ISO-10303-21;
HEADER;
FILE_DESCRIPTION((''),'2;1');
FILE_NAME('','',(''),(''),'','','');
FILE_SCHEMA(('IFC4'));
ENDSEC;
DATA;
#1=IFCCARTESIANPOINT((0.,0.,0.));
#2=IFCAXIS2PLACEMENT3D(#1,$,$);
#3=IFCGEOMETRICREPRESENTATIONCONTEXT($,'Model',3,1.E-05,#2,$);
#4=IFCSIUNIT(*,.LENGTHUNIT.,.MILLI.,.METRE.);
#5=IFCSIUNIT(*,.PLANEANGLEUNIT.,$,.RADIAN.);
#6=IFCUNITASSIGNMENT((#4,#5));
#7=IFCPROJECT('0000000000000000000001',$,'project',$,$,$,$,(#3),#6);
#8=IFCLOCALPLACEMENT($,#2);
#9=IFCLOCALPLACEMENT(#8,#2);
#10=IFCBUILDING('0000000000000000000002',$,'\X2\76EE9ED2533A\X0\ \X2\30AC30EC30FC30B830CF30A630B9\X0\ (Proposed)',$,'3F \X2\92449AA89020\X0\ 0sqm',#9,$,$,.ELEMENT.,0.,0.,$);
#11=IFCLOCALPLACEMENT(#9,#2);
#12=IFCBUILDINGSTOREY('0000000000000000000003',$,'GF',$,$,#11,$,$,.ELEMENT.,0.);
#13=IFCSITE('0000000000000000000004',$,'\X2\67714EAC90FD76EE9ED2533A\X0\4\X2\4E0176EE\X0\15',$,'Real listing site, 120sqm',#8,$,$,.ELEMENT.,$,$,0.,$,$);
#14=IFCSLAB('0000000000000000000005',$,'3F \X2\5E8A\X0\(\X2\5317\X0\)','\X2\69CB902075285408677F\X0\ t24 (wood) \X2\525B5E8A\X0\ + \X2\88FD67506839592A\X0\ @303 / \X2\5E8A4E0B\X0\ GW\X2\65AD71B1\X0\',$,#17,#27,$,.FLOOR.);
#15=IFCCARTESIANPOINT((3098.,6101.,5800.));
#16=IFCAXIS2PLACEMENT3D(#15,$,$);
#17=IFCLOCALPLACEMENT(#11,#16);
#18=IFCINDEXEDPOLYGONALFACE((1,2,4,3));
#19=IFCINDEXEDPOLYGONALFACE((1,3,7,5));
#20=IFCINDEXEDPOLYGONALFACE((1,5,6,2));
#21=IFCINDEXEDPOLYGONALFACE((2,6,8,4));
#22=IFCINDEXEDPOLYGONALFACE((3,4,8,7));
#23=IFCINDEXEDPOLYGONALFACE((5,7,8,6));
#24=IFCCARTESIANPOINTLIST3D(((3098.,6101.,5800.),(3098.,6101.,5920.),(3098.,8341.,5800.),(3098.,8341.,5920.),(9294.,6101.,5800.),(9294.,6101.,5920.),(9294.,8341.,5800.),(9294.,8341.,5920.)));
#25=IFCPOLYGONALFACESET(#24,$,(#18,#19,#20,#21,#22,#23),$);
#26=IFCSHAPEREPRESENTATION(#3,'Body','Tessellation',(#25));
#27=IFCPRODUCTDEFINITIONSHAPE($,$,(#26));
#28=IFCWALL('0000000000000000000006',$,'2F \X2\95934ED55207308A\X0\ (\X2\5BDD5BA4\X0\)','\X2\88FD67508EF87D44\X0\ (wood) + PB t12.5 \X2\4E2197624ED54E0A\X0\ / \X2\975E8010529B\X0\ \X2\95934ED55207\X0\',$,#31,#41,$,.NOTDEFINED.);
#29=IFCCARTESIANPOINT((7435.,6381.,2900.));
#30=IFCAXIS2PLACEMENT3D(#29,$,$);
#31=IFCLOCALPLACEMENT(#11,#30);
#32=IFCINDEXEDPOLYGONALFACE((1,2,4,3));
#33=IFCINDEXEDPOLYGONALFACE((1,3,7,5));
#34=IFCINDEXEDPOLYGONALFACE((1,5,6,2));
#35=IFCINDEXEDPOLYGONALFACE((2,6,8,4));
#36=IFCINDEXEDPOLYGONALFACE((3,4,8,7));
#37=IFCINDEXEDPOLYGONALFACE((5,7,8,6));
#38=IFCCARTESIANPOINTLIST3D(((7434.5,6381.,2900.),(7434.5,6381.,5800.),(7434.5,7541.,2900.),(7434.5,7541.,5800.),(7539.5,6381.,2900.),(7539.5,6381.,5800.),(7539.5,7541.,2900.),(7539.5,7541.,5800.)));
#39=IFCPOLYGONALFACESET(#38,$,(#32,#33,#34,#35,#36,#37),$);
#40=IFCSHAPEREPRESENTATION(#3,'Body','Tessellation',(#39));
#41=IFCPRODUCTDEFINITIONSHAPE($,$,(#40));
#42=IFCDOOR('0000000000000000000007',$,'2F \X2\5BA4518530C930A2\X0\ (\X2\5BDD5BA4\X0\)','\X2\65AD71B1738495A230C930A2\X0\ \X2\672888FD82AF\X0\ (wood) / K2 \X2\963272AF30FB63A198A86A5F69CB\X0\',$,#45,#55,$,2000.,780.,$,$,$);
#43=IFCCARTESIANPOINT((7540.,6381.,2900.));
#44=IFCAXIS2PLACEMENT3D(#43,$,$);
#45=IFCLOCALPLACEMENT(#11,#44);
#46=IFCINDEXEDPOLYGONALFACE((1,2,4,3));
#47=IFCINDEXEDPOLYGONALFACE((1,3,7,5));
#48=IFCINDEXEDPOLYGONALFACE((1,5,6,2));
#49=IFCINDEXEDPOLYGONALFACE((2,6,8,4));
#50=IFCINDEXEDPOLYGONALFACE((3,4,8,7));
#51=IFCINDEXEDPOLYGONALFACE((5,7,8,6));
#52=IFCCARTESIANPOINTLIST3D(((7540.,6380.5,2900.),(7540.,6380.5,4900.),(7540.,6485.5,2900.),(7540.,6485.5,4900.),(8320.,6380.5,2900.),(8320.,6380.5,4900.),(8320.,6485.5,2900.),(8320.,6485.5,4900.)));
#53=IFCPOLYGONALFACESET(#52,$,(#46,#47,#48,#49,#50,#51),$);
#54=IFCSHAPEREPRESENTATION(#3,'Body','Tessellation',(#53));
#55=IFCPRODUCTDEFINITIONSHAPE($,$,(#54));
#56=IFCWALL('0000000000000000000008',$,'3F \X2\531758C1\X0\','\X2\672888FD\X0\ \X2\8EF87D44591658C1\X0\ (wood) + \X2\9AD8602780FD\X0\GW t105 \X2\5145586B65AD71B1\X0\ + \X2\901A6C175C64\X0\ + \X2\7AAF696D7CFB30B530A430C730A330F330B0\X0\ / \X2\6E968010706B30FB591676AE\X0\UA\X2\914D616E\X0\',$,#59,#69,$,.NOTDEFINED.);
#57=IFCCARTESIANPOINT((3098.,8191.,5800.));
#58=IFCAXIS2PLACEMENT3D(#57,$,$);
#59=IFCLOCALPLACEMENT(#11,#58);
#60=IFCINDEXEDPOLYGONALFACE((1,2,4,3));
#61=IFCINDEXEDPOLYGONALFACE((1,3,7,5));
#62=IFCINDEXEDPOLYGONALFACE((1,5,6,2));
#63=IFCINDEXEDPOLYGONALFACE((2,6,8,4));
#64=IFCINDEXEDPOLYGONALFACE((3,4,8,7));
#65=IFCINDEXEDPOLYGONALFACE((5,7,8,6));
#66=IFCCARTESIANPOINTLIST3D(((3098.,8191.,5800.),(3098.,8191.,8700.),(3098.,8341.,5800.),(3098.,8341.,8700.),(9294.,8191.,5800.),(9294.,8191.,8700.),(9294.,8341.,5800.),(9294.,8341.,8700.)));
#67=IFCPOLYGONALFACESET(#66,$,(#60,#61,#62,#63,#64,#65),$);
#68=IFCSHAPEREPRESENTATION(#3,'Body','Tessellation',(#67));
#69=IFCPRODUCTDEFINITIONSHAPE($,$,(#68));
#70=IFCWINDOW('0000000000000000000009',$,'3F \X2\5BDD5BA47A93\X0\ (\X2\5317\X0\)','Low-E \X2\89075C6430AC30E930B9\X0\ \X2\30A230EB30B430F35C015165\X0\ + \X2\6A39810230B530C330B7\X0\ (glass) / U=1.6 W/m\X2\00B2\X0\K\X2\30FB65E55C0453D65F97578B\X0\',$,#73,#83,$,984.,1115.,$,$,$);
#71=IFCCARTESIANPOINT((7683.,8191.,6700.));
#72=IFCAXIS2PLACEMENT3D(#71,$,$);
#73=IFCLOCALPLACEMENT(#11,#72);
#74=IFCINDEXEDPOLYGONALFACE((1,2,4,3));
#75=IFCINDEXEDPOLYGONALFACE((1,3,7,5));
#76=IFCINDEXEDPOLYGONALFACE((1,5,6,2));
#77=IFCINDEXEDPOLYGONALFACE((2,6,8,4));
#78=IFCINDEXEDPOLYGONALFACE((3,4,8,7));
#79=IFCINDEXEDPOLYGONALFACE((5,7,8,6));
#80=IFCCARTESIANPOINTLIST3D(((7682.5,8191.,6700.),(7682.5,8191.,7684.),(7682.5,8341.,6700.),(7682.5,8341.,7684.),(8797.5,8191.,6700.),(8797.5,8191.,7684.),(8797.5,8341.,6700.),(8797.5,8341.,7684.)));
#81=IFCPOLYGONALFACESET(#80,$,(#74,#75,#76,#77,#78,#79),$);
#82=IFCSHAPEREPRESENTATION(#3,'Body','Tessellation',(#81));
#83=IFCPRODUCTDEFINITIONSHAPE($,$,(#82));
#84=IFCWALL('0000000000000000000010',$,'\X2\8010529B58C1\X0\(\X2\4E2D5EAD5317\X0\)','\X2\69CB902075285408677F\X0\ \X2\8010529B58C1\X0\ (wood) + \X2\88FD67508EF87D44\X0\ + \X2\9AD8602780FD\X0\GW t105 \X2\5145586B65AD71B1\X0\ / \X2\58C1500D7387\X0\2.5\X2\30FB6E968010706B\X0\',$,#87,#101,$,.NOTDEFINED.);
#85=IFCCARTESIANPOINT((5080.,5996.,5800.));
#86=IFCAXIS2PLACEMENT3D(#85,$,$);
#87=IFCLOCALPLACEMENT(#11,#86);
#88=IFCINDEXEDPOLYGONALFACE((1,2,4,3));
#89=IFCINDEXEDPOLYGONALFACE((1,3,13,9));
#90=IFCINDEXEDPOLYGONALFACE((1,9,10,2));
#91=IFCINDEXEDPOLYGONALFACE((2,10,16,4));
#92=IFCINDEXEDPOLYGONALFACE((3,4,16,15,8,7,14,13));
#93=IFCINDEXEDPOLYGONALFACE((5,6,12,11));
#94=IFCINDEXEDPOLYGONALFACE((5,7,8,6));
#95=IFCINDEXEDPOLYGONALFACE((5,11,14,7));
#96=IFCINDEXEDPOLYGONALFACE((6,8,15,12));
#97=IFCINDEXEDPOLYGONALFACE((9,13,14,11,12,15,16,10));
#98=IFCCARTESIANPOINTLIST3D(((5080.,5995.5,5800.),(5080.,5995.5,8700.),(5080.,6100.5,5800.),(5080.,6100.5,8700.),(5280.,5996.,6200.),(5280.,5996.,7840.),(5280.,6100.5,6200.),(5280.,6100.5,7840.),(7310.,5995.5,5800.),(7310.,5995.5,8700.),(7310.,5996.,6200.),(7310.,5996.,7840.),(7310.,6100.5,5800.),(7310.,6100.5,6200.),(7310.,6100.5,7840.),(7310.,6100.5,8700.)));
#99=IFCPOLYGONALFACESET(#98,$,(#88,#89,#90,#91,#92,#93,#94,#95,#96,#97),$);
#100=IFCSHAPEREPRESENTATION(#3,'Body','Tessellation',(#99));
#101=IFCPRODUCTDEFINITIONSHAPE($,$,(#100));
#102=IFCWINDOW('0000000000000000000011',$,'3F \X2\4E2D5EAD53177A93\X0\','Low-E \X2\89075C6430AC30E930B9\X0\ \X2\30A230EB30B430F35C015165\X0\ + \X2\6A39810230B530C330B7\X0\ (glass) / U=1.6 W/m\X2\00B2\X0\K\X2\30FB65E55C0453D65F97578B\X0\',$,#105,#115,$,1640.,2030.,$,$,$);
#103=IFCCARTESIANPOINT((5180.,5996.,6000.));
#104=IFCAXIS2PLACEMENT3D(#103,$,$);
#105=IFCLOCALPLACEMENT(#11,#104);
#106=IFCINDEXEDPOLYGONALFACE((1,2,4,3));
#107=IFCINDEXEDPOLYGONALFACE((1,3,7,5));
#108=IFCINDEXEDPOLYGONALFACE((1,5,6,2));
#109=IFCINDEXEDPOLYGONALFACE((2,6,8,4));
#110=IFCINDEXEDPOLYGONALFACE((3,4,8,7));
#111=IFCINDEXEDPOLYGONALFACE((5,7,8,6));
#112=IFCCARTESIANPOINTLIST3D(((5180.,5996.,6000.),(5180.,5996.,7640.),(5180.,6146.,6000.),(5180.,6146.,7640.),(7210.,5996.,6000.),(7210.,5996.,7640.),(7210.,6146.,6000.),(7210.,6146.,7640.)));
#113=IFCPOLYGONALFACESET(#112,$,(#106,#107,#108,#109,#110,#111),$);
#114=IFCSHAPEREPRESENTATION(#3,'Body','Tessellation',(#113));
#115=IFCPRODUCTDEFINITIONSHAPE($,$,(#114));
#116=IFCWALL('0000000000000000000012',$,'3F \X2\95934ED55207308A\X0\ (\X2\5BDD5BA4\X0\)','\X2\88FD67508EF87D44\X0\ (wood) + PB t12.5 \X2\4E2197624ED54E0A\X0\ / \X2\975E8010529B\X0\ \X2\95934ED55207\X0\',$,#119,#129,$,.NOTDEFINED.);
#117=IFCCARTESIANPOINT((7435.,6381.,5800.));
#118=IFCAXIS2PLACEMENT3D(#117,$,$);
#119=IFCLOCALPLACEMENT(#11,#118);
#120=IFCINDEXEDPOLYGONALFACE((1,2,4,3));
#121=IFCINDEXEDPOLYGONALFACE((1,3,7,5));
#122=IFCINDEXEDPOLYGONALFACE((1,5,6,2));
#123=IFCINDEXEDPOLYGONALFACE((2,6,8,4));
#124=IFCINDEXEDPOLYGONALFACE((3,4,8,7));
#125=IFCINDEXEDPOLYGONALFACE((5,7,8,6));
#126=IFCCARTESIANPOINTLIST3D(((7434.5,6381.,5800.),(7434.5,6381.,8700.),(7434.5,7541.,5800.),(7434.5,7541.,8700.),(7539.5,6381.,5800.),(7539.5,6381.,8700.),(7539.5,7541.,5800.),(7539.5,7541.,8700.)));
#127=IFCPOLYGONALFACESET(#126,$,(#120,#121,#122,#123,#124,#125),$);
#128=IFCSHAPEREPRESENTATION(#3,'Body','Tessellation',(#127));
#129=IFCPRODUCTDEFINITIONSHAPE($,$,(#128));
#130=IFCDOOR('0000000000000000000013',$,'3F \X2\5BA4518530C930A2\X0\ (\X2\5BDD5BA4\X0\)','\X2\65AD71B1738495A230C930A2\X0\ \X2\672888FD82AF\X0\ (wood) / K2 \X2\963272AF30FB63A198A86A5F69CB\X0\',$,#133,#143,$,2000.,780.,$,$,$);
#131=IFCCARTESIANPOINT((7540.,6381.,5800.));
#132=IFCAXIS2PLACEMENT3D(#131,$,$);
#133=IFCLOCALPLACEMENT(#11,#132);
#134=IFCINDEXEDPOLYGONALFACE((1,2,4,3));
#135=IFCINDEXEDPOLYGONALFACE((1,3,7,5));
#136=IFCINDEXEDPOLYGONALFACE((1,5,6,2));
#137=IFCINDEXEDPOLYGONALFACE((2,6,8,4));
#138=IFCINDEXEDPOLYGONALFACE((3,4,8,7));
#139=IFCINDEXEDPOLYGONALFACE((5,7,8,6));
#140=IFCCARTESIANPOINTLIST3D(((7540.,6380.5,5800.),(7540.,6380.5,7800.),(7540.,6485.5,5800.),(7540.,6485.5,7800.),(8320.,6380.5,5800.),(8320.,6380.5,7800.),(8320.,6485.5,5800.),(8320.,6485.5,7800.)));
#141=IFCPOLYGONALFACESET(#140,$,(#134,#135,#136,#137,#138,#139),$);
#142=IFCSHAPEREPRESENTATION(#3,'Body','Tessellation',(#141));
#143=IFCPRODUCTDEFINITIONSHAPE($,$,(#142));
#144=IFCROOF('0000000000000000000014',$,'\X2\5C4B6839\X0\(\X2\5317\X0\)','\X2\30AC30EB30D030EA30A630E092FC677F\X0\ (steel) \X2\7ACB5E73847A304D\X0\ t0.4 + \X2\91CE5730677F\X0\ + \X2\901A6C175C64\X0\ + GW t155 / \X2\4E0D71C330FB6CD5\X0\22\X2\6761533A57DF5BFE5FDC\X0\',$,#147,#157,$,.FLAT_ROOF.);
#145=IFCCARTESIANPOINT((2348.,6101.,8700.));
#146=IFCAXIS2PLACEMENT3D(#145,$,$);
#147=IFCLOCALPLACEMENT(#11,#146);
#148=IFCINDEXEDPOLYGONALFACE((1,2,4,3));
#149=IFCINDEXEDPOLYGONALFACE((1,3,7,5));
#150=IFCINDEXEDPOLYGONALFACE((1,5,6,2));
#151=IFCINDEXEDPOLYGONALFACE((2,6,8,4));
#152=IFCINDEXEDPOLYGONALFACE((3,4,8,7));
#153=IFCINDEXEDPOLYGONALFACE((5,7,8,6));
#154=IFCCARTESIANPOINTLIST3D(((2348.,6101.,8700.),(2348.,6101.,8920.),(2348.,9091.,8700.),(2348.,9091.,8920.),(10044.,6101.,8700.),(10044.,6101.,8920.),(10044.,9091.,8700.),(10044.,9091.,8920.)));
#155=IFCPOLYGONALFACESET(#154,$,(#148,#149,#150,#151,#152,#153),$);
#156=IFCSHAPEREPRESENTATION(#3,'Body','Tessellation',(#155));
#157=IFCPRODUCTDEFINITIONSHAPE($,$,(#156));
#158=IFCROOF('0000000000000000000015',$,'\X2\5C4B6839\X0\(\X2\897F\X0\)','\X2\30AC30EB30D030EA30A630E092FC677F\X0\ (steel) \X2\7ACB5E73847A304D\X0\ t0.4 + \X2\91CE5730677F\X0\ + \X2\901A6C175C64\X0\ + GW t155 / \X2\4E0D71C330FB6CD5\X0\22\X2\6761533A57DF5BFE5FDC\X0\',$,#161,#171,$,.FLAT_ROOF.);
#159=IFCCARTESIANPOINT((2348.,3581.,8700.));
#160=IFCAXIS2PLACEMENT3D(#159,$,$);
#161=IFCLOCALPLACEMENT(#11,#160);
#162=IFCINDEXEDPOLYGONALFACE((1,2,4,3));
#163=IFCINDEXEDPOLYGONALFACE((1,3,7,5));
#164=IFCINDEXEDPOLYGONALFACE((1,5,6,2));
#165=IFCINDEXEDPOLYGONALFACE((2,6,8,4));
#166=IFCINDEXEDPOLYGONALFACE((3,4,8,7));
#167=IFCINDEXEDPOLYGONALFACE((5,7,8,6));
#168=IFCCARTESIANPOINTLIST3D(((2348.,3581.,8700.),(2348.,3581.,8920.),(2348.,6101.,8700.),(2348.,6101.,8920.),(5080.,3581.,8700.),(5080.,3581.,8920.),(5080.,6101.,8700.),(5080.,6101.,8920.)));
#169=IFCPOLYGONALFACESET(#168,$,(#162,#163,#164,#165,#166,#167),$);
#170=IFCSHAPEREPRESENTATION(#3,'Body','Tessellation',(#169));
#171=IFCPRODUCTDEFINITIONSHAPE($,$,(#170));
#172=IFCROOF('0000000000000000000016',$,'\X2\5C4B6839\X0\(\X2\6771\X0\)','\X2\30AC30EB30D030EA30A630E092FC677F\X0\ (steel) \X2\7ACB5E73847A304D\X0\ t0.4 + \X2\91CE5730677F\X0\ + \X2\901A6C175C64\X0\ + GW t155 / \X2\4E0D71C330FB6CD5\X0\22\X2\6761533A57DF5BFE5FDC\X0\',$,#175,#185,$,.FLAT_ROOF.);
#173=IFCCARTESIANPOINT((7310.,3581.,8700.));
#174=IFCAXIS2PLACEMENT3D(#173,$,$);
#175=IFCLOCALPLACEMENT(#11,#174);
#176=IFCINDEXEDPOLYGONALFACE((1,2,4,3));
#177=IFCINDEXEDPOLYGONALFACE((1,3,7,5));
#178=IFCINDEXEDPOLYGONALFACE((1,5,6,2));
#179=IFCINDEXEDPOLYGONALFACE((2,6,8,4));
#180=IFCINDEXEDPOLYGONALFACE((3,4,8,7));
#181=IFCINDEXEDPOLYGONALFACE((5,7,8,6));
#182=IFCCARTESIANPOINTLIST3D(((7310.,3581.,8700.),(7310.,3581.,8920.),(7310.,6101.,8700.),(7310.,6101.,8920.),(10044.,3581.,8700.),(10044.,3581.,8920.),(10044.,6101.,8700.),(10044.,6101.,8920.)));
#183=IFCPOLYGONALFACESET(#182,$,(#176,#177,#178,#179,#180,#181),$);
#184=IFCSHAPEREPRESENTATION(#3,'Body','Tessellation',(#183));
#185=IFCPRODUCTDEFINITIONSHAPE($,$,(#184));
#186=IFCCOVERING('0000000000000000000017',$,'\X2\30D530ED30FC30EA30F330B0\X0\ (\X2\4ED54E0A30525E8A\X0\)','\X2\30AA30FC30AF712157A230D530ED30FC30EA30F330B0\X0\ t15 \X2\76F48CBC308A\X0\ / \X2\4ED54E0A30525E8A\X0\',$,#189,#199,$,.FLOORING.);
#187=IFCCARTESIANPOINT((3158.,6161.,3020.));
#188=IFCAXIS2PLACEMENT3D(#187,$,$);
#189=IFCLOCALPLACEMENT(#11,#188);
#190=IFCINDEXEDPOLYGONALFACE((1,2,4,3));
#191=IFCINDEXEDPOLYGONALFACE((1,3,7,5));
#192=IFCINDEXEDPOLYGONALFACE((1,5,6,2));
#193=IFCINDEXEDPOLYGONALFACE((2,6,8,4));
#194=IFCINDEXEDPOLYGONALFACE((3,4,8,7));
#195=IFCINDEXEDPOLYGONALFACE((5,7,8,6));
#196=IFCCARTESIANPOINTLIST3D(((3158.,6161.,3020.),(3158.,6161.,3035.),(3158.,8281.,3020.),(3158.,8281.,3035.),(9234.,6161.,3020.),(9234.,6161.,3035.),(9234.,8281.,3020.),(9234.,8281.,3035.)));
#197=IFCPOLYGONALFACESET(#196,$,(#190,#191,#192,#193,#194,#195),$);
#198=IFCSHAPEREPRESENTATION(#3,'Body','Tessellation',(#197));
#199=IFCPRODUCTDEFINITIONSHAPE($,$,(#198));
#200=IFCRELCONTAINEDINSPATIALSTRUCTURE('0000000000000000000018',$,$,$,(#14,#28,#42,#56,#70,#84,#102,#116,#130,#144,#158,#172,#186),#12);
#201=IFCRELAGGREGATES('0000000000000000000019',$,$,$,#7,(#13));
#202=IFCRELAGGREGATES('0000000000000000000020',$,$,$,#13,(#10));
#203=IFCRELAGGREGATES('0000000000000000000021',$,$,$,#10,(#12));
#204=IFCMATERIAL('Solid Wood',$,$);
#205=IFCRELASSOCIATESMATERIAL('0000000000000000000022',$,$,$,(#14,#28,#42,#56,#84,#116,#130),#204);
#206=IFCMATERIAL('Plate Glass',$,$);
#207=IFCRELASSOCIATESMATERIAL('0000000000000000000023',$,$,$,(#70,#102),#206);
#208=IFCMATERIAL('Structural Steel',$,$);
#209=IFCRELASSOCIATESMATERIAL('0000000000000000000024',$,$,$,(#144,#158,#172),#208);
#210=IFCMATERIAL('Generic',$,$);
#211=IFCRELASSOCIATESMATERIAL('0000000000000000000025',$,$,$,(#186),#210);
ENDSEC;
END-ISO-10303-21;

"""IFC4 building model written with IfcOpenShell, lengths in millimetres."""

from ifc_helpers import new_model, si_unit, frame, frame_2d, origin, place, context, project, spatial, rectangle, extrude, material, element, fill, save


model = new_model("IFC4")

# Units and contexts
model_context = context("Model", 3, precision=1e-05, world=origin())
ifc_project = project(units=[si_unit("LENGTHUNIT", "METRE", prefix="MILLI"), si_unit("PLANEANGLEUNIT", "RADIAN")], contexts=[model_context])

# Site, building, storey
site_placement = place(None, origin())
site = spatial("IfcSite", under=ifc_project, at=site_placement, Name="東京都目黒区4丁目15", ObjectType="Real listing site, 120sqm", CompositionType="ELEMENT", RefElevation=0.0)
building_placement = place(site_placement, origin())
building = spatial("IfcBuilding", under=site, at=building_placement, Name="目黒区 ガレージハウス (Proposed)", ObjectType="3F 鉄骨造 0sqm", CompositionType="ELEMENT", ElevationOfRefHeight=0.0, ElevationOfTerrain=0.0)
storey_placement = place(building_placement, origin())
storey = spatial("IfcBuildingStorey", under=building, at=storey_placement, Name="GF", CompositionType="ELEMENT", Elevation=0.0)

# Slab
ifc_material_1 = material(Name="Solid Wood")
slab_placement = place(storey_placement, frame((3098.0, 6101.0, 5800.0)))
element("IfcSlab", 1, at=slab_placement, inside=storey, material=ifc_material_1, Name="3F 床(北)", Description="構造用合板 t24 (wood) 剛床 + 製材根太 @303 / 床下 GW断熱", PredefinedType="FLOOR", context=model_context, shape_type="SweptSolid", body=[
    extrude(rectangle(XDim=6196.0, YDim=2240.0, at=frame_2d((3098.0, 1120.0))), frame((3098.0, 6101.0, 5800.0)), (0.0, 0.0, 1.0), 120.0),
])

# Wall
wall_1_placement = place(storey_placement, frame((7435.0, 6381.0, 2900.0)))
element("IfcWall", 2, at=wall_1_placement, inside=storey, material=ifc_material_1, Name="2F 間仕切り (寝室)", Description="製材軸組 (wood) + PB t12.5 両面仕上 / 非耐力 間仕切", PredefinedType="NOTDEFINED", context=model_context, shape_type="SweptSolid", body=[
    extrude(rectangle(XDim=105.0, YDim=1160.0, at=frame_2d((52.0, 580.0))), frame((7435.0, 6381.0, 2900.0)), (0.0, 0.0, 1.0), 2900.0),
])

# Door
door_1_placement = place(storey_placement, frame((7540.0, 6381.0, 2900.0)))
element("IfcDoor", 3, at=door_1_placement, inside=storey, material=ifc_material_1, Name="2F 室内ドア (寝室)", Description="断熱玄関ドア 木製芯 (wood) / K2 防犯・採風機構", OverallHeight=2000.0, OverallWidth=780.0, context=model_context, shape_type="SweptSolid", body=[
    extrude(rectangle(XDim=780.0, YDim=105.0, at=frame_2d((390.0, 52.0))), frame((7540.0, 6381.0, 2900.0)), (0.0, 0.0, 1.0), 2000.0),
])

# Walls, openings, windows
wall_2_placement = place(storey_placement, frame((3098.0, 8191.0, 5800.0)))
wall_2 = element("IfcWall", 4, at=wall_2_placement, inside=storey, material=ifc_material_1, Name="3F 北壁", Description="木製 軸組外壁 (wood) + 高性能GW t105 充填断熱 + 通気層 + 窯業系サイディング / 準耐火・外皮UA配慮", PredefinedType="NOTDEFINED", context=model_context, shape_type="SweptSolid", body=[
    extrude(rectangle(XDim=6196.0, YDim=150.0, at=frame_2d((3098.0, 75.0))), frame((3098.0, 8191.0, 5800.0)), (0.0, 0.0, 1.0), 2900.0),
])
opening_1_placement = place(storey_placement, frame((7683.0, 8191.0, 6700.0)))
opening_1 = element("IfcOpeningElement", 5, at=opening_1_placement, cuts=wall_2, PredefinedType="NOTDEFINED", context=model_context, shape_type="SweptSolid", body=[
    extrude(rectangle(XDim=1115.0, YDim=150.0, at=frame_2d((557.0, 75.0))), frame((7683.0, 8191.0, 6700.0)), (0.0, 0.0, 1.0), 984.0),
])
ifc_material_2 = material(Name="Plate Glass")
window_1_placement = place(storey_placement, frame((7683.0, 8191.0, 6700.0)))
window_1 = element("IfcWindow", 6, at=window_1_placement, inside=storey, material=ifc_material_2, Name="3F 寝室窓 (北)", Description="Low-E 複層ガラス アルゴン封入 + 樹脂サッシ (glass) / U=1.6 W/m²K・日射取得型", OverallHeight=984.0, OverallWidth=1115.0, context=model_context, shape_type="SweptSolid", body=[
    extrude(rectangle(XDim=1115.0, YDim=150.0, at=frame_2d((557.0, 75.0))), frame((7683.0, 8191.0, 6700.0)), (0.0, 0.0, 1.0), 984.0),
])
fill(opening_1, window_1)
wall_3_placement = place(storey_placement, frame((5080.0, 5996.0, 5800.0)))
wall_3 = element("IfcWall", 7, at=wall_3_placement, inside=storey, material=ifc_material_1, Name="耐力壁(中庭北)", Description="構造用合板 耐力壁 (wood) + 製材軸組 + 高性能GW t105 充填断熱 / 壁倍率2.5・準耐火", PredefinedType="NOTDEFINED", context=model_context, shape_type="SweptSolid", body=[
    extrude(rectangle(XDim=2230.0, YDim=105.0, at=frame_2d((1115.0, 52.0))), frame((5080.0, 5996.0, 5800.0)), (0.0, 0.0, 1.0), 2900.0),
])
opening_2_placement = place(storey_placement, frame((5180.0, 5996.0, 6000.0)))
opening_2 = element("IfcOpeningElement", 8, at=opening_2_placement, cuts=wall_3, PredefinedType="NOTDEFINED", context=model_context, shape_type="SweptSolid", body=[
    extrude(rectangle(XDim=2030.0, YDim=150.0, at=frame_2d((1015.0, 75.0))), frame((5180.0, 5996.0, 6000.0)), (0.0, 0.0, 1.0), 1640.0),
])
window_2_placement = place(storey_placement, frame((5180.0, 5996.0, 6000.0)))
window_2 = element("IfcWindow", 9, at=window_2_placement, inside=storey, material=ifc_material_2, Name="3F 中庭北窓", Description="Low-E 複層ガラス アルゴン封入 + 樹脂サッシ (glass) / U=1.6 W/m²K・日射取得型", OverallHeight=1640.0, OverallWidth=2030.0, context=model_context, shape_type="SweptSolid", body=[
    extrude(rectangle(XDim=2030.0, YDim=150.0, at=frame_2d((1015.0, 75.0))), frame((5180.0, 5996.0, 6000.0)), (0.0, 0.0, 1.0), 1640.0),
])
fill(opening_2, window_2)

# Wall
wall_4_placement = place(storey_placement, frame((7435.0, 6381.0, 5800.0)))
element("IfcWall", 10, at=wall_4_placement, inside=storey, material=ifc_material_1, Name="3F 間仕切り (寝室)", Description="製材軸組 (wood) + PB t12.5 両面仕上 / 非耐力 間仕切", PredefinedType="NOTDEFINED", context=model_context, shape_type="SweptSolid", body=[
    extrude(rectangle(XDim=105.0, YDim=1160.0, at=frame_2d((52.0, 580.0))), frame((7435.0, 6381.0, 5800.0)), (0.0, 0.0, 1.0), 2900.0),
])

# Door
door_2_placement = place(storey_placement, frame((7540.0, 6381.0, 5800.0)))
element("IfcDoor", 11, at=door_2_placement, inside=storey, material=ifc_material_1, Name="3F 室内ドア (寝室)", Description="断熱玄関ドア 木製芯 (wood) / K2 防犯・採風機構", OverallHeight=2000.0, OverallWidth=780.0, context=model_context, shape_type="SweptSolid", body=[
    extrude(rectangle(XDim=780.0, YDim=105.0, at=frame_2d((390.0, 52.0))), frame((7540.0, 6381.0, 5800.0)), (0.0, 0.0, 1.0), 2000.0),
])

# Roofs
ifc_material_3 = material(Name="Structural Steel")
for number, where, name in (
    (12, (2348.0, 6101.0, 8700.0), "屋根(北)"),
):
    element("IfcRoof", number, at=place(storey_placement, frame(where)), inside=storey, material=ifc_material_3, Name=name, Description="ガルバリウム鋼板 (steel) 立平葺き t0.4 + 野地板 + 通気層 + GW t155 / 不燃・法22条区域対応", PredefinedType="FLAT_ROOF", context=model_context, shape_type="SweptSolid", body=[
        extrude(rectangle(XDim=7696.0, YDim=2990.0, at=frame_2d((3848.0, 1495.0))), frame((2348.0, 6101.0, 8700.0)), (0.0, 0.0, 1.0), 220.0),
    ])
roof_1_placement = place(storey_placement, frame((2348.0, 3581.0, 8700.0)))
element("IfcRoof", 13, at=roof_1_placement, inside=storey, material=ifc_material_3, Name="屋根(西)", Description="ガルバリウム鋼板 (steel) 立平葺き t0.4 + 野地板 + 通気層 + GW t155 / 不燃・法22条区域対応", PredefinedType="FLAT_ROOF", context=model_context, shape_type="SweptSolid", body=[
    extrude(rectangle(XDim=2732.0, YDim=2520.0, at=frame_2d((1366.0, 1260.0))), frame((2348.0, 3581.0, 8700.0)), (0.0, 0.0, 1.0), 220.0),
])
roof_2_placement = place(storey_placement, frame((7310.0, 3581.0, 8700.0)))
element("IfcRoof", 14, at=roof_2_placement, inside=storey, material=ifc_material_3, Name="屋根(東)", Description="ガルバリウム鋼板 (steel) 立平葺き t0.4 + 野地板 + 通気層 + GW t155 / 不燃・法22条区域対応", PredefinedType="FLAT_ROOF", context=model_context, shape_type="SweptSolid", body=[
    extrude(rectangle(XDim=2734.0, YDim=2520.0, at=frame_2d((1367.0, 1260.0))), frame((7310.0, 3581.0, 8700.0)), (0.0, 0.0, 1.0), 220.0),
])

# Covering
ifc_material_4 = material(Name="Generic")
covering_1_placement = place(storey_placement, frame((3158.0, 6161.0, 3020.0)))
element("IfcCovering", 15, at=covering_1_placement, inside=storey, material=ifc_material_4, Name="フローリング (仕上げ床)", Description="オーク無垢フローリング t15 直貼り / 仕上げ床", PredefinedType="FLOORING", context=model_context, shape_type="SweptSolid", body=[
    extrude(rectangle(XDim=6076.0, YDim=2120.0, at=frame_2d((3038.0, 1060.0))), frame((3158.0, 6161.0, 3020.0)), (0.0, 0.0, 1.0), 15.0),
])

save(model, "model.ifc")
